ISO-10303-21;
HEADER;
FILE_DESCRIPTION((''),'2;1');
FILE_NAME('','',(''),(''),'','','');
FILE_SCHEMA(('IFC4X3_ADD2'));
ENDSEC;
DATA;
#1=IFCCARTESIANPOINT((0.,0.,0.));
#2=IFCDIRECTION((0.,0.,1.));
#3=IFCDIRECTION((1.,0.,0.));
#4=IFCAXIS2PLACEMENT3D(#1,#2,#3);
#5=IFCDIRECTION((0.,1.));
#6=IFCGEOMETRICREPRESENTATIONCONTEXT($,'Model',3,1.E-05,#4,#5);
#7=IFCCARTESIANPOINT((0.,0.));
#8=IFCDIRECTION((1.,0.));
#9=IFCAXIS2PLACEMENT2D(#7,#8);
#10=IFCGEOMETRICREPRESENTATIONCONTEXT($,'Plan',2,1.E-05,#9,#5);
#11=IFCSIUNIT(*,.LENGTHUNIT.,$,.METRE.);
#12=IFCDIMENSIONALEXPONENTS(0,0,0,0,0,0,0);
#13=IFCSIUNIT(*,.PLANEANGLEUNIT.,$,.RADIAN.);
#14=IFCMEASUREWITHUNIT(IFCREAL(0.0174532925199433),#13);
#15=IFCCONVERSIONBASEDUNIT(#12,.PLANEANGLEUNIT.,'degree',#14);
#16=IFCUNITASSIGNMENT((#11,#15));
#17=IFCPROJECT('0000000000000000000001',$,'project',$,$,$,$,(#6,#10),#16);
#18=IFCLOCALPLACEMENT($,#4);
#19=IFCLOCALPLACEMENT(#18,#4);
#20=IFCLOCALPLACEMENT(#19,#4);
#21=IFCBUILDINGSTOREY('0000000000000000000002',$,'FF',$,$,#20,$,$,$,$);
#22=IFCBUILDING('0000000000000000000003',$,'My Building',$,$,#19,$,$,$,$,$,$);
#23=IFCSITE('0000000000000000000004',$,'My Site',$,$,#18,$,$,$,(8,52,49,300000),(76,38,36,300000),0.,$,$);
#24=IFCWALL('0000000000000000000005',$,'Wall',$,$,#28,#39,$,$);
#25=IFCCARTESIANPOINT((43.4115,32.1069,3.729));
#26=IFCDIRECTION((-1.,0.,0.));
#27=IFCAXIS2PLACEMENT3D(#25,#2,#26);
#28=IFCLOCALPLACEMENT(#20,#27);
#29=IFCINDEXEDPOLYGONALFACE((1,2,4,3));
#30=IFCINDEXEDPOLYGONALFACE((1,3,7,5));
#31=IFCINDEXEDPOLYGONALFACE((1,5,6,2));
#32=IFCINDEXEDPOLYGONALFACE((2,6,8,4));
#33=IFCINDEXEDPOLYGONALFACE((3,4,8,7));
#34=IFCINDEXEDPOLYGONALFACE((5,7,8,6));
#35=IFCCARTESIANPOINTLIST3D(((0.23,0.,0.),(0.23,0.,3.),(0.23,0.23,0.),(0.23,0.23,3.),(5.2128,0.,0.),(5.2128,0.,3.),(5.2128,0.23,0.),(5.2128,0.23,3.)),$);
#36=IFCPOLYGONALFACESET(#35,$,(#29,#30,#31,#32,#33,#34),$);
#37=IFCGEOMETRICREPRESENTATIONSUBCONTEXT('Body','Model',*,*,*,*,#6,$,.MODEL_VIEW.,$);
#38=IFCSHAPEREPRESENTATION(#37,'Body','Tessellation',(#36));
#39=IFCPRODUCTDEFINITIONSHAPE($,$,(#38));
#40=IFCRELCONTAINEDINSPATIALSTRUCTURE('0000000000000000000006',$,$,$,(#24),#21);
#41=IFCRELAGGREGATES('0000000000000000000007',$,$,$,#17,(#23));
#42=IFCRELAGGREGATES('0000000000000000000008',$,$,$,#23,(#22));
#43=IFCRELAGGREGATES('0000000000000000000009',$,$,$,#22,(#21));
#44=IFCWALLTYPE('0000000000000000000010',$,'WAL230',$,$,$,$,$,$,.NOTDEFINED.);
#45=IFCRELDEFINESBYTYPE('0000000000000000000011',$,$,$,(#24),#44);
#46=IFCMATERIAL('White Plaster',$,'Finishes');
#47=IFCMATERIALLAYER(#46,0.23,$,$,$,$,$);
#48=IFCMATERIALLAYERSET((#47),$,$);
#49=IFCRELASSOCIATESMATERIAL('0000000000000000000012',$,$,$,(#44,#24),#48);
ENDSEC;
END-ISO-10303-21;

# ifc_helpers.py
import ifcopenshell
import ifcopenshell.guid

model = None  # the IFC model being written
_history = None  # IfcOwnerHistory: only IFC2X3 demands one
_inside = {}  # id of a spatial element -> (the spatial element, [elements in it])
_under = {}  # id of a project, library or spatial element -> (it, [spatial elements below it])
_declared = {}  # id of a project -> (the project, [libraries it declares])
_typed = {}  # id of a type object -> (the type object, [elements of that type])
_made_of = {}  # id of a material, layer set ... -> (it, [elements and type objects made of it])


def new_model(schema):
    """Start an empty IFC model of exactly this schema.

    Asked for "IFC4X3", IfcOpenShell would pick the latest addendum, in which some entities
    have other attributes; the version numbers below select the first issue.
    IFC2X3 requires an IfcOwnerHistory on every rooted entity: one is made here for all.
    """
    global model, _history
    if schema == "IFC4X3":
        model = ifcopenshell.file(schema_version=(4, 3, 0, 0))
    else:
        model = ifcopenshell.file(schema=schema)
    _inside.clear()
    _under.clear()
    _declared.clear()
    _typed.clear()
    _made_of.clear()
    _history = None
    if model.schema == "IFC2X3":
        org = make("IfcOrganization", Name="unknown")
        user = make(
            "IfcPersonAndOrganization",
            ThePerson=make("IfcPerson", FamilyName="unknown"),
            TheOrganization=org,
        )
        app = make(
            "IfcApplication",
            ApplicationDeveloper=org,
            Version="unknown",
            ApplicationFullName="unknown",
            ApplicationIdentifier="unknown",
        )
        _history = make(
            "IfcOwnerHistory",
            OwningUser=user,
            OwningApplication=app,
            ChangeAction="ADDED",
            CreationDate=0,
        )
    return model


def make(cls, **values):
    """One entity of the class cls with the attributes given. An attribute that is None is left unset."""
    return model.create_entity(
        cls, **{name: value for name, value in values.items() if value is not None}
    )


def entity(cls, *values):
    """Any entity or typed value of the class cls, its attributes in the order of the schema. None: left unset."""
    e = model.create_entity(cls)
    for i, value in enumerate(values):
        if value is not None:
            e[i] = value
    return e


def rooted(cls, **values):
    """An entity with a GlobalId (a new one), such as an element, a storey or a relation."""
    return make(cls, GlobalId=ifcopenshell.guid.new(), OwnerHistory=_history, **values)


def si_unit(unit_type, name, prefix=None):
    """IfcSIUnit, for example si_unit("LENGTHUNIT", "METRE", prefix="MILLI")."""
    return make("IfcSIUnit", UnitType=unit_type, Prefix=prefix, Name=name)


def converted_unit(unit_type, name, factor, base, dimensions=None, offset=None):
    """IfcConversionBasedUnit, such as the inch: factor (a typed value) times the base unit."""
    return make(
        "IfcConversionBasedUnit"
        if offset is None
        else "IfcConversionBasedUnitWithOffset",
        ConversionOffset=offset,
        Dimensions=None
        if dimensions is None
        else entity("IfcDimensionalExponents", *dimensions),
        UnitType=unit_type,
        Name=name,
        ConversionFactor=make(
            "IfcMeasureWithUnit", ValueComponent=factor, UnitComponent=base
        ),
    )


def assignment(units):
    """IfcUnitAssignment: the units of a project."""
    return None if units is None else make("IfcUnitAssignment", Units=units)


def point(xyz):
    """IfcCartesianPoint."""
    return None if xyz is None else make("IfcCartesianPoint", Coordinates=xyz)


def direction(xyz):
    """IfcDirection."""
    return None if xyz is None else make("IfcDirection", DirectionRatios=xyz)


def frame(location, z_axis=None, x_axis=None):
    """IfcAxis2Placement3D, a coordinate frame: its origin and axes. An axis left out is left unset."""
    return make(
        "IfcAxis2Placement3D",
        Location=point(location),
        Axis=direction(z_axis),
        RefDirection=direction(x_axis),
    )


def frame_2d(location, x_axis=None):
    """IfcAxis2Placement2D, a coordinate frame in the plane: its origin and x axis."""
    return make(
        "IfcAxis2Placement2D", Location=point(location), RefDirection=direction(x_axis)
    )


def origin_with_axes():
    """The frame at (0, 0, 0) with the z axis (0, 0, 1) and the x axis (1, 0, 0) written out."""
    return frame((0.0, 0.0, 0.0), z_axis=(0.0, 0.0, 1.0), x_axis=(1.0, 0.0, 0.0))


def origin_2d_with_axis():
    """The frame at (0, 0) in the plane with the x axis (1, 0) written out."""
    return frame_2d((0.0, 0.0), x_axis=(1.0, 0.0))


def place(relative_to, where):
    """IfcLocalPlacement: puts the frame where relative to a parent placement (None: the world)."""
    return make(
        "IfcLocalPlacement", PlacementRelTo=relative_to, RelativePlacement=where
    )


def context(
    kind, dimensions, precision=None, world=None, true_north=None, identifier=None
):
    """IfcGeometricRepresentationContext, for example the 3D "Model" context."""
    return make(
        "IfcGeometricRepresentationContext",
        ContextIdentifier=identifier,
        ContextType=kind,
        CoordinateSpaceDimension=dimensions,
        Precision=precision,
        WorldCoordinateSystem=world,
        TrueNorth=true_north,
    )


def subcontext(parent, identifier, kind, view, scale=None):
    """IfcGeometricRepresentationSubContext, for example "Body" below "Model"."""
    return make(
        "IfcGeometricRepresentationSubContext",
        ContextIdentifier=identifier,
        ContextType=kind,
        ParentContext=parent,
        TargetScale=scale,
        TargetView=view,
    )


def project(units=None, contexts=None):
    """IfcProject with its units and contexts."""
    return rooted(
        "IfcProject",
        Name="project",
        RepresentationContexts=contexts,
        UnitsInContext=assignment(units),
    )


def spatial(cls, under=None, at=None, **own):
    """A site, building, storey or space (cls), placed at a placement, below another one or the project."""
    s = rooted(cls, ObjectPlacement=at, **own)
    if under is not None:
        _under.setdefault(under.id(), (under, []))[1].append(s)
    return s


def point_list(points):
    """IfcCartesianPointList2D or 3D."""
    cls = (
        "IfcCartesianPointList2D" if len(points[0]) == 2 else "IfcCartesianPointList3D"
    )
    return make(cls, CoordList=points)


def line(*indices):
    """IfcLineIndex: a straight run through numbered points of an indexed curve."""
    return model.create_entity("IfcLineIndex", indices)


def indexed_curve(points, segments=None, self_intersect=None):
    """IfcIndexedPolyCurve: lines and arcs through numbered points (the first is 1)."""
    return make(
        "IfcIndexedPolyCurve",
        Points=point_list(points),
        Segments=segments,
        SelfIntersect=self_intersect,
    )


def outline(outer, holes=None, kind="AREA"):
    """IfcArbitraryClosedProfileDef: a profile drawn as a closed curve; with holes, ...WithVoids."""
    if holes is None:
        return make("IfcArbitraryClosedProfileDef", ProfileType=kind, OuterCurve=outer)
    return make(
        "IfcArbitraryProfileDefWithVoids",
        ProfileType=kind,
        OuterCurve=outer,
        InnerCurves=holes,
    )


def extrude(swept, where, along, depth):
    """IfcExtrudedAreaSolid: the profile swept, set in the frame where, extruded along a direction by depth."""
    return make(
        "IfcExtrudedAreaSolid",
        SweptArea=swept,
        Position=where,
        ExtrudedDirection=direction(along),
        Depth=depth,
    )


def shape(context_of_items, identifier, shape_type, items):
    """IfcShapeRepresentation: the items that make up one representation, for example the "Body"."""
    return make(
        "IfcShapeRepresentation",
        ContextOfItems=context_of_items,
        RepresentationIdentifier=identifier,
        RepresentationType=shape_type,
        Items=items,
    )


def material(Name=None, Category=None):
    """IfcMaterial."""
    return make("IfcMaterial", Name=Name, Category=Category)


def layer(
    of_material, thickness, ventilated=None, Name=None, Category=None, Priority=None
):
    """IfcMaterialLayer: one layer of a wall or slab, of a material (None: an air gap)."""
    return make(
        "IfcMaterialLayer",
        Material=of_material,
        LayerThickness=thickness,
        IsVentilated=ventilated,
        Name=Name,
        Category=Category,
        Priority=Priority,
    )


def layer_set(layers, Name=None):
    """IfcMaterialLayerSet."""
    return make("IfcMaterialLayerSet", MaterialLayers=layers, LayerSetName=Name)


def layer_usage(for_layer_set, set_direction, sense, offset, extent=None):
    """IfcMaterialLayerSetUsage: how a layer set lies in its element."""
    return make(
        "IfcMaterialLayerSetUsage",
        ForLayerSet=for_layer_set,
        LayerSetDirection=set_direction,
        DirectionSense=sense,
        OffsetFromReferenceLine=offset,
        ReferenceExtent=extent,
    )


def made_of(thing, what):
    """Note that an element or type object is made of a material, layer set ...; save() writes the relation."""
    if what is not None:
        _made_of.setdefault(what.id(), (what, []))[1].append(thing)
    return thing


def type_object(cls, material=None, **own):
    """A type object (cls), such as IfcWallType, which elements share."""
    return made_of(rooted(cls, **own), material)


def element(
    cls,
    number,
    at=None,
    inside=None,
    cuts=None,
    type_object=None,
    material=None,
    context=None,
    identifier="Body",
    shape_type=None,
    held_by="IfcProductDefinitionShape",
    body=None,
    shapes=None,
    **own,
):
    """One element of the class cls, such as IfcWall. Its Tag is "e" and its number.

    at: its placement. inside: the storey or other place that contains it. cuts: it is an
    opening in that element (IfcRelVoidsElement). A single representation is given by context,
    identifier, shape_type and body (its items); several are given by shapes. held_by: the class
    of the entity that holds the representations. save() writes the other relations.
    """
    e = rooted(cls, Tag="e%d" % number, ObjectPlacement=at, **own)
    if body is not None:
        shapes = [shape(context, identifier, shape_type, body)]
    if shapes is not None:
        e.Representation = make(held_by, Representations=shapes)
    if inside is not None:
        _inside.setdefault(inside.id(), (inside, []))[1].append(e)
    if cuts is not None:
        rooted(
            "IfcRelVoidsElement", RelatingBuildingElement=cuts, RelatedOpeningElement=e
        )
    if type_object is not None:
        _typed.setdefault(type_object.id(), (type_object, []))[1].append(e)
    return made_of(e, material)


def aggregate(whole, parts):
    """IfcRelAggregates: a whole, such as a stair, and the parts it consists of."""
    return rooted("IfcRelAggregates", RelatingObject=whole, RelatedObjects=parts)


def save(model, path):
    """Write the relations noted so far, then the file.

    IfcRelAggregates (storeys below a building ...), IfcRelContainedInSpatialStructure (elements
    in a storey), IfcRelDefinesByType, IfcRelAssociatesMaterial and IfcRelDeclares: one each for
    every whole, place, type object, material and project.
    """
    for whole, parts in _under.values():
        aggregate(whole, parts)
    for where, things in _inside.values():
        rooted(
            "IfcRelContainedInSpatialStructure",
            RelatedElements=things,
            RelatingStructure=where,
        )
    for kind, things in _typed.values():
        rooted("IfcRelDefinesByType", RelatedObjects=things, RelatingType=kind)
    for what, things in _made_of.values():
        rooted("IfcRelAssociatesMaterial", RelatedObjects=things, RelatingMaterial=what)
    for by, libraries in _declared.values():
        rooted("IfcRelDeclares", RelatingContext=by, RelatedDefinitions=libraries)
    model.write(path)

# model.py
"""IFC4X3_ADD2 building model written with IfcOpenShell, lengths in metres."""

from ifc_helpers import new_model, entity, si_unit, converted_unit, direction, frame, origin_with_axes, origin_2d_with_axis, place, context, subcontext, project, spatial, line, indexed_curve, outline, extrude, material, layer, layer_set, layer_usage, type_object, element, save


model = new_model("IFC4X3_ADD2")

# Units and contexts
model_context = context("Model", 3, precision=1e-05, world=origin_with_axes(), true_north=direction((0.0, 1.0)))
plan_context = context("Plan", 2, precision=1e-05, world=origin_2d_with_axis(), true_north=direction((0.0, 1.0)))
body_context_1 = subcontext(model_context, "Body", "Model", "MODEL_VIEW")
ifc_project = project(units=[si_unit("LENGTHUNIT", "METRE"), converted_unit("PLANEANGLEUNIT", "degree", entity("IfcReal", 0.0174532925199433), si_unit("PLANEANGLEUNIT", "RADIAN"), dimensions=[0, 0, 0, 0, 0, 0, 0])], contexts=[model_context, plan_context])

# Site, building, storey
site_placement = place(None, origin_with_axes())
site = spatial("IfcSite", under=ifc_project, at=site_placement, Name="My Site", RefLatitude=(8, 52, 49, 300000), RefLongitude=(76, 38, 36, 300000), RefElevation=0.0)
building_placement = place(site_placement, origin_with_axes())
building = spatial("IfcBuilding", under=site, at=building_placement, Name="My Building")
storey_placement = place(building_placement, origin_with_axes())
storey = spatial("IfcBuildingStorey", under=building, at=storey_placement, Name="FF")

# Shared definitions
ifc_material_1 = material(Name="White Plaster", Category="Finishes")
ifc_layer_1 = layer(ifc_material_1, 0.23)
ifc_layer_set_1 = layer_set([ifc_layer_1])
wall_type_1 = type_object("IfcWallType", Name="WAL230", PredefinedType="NOTDEFINED", material=ifc_layer_set_1)

# Wall
ifc_layer_usage_1 = layer_usage(ifc_layer_set_1, "AXIS2", "POSITIVE", 0.0)
wall_1_placement = place(storey_placement, frame((43.4115, 32.1069, 3.729), z_axis=(0.0, 0.0, 1.0), x_axis=(-1.0, 0.0, 0.0)))
element("IfcWall", 1, at=wall_1_placement, inside=storey, type_object=wall_type_1, material=ifc_layer_usage_1, Name="Wall", context=body_context_1, shape_type="SweptSolid", body=[
    extrude(outline(indexed_curve([(0.23, 0.0), (0.23, 0.23), (5.2128, 0.23), (5.2128, 0.0)], segments=[line(1, 2, 3, 4, 1)])), origin_with_axes(), (0.0, 0.0, 1.0), 3.0),
])

save(model, "model.ifc")
